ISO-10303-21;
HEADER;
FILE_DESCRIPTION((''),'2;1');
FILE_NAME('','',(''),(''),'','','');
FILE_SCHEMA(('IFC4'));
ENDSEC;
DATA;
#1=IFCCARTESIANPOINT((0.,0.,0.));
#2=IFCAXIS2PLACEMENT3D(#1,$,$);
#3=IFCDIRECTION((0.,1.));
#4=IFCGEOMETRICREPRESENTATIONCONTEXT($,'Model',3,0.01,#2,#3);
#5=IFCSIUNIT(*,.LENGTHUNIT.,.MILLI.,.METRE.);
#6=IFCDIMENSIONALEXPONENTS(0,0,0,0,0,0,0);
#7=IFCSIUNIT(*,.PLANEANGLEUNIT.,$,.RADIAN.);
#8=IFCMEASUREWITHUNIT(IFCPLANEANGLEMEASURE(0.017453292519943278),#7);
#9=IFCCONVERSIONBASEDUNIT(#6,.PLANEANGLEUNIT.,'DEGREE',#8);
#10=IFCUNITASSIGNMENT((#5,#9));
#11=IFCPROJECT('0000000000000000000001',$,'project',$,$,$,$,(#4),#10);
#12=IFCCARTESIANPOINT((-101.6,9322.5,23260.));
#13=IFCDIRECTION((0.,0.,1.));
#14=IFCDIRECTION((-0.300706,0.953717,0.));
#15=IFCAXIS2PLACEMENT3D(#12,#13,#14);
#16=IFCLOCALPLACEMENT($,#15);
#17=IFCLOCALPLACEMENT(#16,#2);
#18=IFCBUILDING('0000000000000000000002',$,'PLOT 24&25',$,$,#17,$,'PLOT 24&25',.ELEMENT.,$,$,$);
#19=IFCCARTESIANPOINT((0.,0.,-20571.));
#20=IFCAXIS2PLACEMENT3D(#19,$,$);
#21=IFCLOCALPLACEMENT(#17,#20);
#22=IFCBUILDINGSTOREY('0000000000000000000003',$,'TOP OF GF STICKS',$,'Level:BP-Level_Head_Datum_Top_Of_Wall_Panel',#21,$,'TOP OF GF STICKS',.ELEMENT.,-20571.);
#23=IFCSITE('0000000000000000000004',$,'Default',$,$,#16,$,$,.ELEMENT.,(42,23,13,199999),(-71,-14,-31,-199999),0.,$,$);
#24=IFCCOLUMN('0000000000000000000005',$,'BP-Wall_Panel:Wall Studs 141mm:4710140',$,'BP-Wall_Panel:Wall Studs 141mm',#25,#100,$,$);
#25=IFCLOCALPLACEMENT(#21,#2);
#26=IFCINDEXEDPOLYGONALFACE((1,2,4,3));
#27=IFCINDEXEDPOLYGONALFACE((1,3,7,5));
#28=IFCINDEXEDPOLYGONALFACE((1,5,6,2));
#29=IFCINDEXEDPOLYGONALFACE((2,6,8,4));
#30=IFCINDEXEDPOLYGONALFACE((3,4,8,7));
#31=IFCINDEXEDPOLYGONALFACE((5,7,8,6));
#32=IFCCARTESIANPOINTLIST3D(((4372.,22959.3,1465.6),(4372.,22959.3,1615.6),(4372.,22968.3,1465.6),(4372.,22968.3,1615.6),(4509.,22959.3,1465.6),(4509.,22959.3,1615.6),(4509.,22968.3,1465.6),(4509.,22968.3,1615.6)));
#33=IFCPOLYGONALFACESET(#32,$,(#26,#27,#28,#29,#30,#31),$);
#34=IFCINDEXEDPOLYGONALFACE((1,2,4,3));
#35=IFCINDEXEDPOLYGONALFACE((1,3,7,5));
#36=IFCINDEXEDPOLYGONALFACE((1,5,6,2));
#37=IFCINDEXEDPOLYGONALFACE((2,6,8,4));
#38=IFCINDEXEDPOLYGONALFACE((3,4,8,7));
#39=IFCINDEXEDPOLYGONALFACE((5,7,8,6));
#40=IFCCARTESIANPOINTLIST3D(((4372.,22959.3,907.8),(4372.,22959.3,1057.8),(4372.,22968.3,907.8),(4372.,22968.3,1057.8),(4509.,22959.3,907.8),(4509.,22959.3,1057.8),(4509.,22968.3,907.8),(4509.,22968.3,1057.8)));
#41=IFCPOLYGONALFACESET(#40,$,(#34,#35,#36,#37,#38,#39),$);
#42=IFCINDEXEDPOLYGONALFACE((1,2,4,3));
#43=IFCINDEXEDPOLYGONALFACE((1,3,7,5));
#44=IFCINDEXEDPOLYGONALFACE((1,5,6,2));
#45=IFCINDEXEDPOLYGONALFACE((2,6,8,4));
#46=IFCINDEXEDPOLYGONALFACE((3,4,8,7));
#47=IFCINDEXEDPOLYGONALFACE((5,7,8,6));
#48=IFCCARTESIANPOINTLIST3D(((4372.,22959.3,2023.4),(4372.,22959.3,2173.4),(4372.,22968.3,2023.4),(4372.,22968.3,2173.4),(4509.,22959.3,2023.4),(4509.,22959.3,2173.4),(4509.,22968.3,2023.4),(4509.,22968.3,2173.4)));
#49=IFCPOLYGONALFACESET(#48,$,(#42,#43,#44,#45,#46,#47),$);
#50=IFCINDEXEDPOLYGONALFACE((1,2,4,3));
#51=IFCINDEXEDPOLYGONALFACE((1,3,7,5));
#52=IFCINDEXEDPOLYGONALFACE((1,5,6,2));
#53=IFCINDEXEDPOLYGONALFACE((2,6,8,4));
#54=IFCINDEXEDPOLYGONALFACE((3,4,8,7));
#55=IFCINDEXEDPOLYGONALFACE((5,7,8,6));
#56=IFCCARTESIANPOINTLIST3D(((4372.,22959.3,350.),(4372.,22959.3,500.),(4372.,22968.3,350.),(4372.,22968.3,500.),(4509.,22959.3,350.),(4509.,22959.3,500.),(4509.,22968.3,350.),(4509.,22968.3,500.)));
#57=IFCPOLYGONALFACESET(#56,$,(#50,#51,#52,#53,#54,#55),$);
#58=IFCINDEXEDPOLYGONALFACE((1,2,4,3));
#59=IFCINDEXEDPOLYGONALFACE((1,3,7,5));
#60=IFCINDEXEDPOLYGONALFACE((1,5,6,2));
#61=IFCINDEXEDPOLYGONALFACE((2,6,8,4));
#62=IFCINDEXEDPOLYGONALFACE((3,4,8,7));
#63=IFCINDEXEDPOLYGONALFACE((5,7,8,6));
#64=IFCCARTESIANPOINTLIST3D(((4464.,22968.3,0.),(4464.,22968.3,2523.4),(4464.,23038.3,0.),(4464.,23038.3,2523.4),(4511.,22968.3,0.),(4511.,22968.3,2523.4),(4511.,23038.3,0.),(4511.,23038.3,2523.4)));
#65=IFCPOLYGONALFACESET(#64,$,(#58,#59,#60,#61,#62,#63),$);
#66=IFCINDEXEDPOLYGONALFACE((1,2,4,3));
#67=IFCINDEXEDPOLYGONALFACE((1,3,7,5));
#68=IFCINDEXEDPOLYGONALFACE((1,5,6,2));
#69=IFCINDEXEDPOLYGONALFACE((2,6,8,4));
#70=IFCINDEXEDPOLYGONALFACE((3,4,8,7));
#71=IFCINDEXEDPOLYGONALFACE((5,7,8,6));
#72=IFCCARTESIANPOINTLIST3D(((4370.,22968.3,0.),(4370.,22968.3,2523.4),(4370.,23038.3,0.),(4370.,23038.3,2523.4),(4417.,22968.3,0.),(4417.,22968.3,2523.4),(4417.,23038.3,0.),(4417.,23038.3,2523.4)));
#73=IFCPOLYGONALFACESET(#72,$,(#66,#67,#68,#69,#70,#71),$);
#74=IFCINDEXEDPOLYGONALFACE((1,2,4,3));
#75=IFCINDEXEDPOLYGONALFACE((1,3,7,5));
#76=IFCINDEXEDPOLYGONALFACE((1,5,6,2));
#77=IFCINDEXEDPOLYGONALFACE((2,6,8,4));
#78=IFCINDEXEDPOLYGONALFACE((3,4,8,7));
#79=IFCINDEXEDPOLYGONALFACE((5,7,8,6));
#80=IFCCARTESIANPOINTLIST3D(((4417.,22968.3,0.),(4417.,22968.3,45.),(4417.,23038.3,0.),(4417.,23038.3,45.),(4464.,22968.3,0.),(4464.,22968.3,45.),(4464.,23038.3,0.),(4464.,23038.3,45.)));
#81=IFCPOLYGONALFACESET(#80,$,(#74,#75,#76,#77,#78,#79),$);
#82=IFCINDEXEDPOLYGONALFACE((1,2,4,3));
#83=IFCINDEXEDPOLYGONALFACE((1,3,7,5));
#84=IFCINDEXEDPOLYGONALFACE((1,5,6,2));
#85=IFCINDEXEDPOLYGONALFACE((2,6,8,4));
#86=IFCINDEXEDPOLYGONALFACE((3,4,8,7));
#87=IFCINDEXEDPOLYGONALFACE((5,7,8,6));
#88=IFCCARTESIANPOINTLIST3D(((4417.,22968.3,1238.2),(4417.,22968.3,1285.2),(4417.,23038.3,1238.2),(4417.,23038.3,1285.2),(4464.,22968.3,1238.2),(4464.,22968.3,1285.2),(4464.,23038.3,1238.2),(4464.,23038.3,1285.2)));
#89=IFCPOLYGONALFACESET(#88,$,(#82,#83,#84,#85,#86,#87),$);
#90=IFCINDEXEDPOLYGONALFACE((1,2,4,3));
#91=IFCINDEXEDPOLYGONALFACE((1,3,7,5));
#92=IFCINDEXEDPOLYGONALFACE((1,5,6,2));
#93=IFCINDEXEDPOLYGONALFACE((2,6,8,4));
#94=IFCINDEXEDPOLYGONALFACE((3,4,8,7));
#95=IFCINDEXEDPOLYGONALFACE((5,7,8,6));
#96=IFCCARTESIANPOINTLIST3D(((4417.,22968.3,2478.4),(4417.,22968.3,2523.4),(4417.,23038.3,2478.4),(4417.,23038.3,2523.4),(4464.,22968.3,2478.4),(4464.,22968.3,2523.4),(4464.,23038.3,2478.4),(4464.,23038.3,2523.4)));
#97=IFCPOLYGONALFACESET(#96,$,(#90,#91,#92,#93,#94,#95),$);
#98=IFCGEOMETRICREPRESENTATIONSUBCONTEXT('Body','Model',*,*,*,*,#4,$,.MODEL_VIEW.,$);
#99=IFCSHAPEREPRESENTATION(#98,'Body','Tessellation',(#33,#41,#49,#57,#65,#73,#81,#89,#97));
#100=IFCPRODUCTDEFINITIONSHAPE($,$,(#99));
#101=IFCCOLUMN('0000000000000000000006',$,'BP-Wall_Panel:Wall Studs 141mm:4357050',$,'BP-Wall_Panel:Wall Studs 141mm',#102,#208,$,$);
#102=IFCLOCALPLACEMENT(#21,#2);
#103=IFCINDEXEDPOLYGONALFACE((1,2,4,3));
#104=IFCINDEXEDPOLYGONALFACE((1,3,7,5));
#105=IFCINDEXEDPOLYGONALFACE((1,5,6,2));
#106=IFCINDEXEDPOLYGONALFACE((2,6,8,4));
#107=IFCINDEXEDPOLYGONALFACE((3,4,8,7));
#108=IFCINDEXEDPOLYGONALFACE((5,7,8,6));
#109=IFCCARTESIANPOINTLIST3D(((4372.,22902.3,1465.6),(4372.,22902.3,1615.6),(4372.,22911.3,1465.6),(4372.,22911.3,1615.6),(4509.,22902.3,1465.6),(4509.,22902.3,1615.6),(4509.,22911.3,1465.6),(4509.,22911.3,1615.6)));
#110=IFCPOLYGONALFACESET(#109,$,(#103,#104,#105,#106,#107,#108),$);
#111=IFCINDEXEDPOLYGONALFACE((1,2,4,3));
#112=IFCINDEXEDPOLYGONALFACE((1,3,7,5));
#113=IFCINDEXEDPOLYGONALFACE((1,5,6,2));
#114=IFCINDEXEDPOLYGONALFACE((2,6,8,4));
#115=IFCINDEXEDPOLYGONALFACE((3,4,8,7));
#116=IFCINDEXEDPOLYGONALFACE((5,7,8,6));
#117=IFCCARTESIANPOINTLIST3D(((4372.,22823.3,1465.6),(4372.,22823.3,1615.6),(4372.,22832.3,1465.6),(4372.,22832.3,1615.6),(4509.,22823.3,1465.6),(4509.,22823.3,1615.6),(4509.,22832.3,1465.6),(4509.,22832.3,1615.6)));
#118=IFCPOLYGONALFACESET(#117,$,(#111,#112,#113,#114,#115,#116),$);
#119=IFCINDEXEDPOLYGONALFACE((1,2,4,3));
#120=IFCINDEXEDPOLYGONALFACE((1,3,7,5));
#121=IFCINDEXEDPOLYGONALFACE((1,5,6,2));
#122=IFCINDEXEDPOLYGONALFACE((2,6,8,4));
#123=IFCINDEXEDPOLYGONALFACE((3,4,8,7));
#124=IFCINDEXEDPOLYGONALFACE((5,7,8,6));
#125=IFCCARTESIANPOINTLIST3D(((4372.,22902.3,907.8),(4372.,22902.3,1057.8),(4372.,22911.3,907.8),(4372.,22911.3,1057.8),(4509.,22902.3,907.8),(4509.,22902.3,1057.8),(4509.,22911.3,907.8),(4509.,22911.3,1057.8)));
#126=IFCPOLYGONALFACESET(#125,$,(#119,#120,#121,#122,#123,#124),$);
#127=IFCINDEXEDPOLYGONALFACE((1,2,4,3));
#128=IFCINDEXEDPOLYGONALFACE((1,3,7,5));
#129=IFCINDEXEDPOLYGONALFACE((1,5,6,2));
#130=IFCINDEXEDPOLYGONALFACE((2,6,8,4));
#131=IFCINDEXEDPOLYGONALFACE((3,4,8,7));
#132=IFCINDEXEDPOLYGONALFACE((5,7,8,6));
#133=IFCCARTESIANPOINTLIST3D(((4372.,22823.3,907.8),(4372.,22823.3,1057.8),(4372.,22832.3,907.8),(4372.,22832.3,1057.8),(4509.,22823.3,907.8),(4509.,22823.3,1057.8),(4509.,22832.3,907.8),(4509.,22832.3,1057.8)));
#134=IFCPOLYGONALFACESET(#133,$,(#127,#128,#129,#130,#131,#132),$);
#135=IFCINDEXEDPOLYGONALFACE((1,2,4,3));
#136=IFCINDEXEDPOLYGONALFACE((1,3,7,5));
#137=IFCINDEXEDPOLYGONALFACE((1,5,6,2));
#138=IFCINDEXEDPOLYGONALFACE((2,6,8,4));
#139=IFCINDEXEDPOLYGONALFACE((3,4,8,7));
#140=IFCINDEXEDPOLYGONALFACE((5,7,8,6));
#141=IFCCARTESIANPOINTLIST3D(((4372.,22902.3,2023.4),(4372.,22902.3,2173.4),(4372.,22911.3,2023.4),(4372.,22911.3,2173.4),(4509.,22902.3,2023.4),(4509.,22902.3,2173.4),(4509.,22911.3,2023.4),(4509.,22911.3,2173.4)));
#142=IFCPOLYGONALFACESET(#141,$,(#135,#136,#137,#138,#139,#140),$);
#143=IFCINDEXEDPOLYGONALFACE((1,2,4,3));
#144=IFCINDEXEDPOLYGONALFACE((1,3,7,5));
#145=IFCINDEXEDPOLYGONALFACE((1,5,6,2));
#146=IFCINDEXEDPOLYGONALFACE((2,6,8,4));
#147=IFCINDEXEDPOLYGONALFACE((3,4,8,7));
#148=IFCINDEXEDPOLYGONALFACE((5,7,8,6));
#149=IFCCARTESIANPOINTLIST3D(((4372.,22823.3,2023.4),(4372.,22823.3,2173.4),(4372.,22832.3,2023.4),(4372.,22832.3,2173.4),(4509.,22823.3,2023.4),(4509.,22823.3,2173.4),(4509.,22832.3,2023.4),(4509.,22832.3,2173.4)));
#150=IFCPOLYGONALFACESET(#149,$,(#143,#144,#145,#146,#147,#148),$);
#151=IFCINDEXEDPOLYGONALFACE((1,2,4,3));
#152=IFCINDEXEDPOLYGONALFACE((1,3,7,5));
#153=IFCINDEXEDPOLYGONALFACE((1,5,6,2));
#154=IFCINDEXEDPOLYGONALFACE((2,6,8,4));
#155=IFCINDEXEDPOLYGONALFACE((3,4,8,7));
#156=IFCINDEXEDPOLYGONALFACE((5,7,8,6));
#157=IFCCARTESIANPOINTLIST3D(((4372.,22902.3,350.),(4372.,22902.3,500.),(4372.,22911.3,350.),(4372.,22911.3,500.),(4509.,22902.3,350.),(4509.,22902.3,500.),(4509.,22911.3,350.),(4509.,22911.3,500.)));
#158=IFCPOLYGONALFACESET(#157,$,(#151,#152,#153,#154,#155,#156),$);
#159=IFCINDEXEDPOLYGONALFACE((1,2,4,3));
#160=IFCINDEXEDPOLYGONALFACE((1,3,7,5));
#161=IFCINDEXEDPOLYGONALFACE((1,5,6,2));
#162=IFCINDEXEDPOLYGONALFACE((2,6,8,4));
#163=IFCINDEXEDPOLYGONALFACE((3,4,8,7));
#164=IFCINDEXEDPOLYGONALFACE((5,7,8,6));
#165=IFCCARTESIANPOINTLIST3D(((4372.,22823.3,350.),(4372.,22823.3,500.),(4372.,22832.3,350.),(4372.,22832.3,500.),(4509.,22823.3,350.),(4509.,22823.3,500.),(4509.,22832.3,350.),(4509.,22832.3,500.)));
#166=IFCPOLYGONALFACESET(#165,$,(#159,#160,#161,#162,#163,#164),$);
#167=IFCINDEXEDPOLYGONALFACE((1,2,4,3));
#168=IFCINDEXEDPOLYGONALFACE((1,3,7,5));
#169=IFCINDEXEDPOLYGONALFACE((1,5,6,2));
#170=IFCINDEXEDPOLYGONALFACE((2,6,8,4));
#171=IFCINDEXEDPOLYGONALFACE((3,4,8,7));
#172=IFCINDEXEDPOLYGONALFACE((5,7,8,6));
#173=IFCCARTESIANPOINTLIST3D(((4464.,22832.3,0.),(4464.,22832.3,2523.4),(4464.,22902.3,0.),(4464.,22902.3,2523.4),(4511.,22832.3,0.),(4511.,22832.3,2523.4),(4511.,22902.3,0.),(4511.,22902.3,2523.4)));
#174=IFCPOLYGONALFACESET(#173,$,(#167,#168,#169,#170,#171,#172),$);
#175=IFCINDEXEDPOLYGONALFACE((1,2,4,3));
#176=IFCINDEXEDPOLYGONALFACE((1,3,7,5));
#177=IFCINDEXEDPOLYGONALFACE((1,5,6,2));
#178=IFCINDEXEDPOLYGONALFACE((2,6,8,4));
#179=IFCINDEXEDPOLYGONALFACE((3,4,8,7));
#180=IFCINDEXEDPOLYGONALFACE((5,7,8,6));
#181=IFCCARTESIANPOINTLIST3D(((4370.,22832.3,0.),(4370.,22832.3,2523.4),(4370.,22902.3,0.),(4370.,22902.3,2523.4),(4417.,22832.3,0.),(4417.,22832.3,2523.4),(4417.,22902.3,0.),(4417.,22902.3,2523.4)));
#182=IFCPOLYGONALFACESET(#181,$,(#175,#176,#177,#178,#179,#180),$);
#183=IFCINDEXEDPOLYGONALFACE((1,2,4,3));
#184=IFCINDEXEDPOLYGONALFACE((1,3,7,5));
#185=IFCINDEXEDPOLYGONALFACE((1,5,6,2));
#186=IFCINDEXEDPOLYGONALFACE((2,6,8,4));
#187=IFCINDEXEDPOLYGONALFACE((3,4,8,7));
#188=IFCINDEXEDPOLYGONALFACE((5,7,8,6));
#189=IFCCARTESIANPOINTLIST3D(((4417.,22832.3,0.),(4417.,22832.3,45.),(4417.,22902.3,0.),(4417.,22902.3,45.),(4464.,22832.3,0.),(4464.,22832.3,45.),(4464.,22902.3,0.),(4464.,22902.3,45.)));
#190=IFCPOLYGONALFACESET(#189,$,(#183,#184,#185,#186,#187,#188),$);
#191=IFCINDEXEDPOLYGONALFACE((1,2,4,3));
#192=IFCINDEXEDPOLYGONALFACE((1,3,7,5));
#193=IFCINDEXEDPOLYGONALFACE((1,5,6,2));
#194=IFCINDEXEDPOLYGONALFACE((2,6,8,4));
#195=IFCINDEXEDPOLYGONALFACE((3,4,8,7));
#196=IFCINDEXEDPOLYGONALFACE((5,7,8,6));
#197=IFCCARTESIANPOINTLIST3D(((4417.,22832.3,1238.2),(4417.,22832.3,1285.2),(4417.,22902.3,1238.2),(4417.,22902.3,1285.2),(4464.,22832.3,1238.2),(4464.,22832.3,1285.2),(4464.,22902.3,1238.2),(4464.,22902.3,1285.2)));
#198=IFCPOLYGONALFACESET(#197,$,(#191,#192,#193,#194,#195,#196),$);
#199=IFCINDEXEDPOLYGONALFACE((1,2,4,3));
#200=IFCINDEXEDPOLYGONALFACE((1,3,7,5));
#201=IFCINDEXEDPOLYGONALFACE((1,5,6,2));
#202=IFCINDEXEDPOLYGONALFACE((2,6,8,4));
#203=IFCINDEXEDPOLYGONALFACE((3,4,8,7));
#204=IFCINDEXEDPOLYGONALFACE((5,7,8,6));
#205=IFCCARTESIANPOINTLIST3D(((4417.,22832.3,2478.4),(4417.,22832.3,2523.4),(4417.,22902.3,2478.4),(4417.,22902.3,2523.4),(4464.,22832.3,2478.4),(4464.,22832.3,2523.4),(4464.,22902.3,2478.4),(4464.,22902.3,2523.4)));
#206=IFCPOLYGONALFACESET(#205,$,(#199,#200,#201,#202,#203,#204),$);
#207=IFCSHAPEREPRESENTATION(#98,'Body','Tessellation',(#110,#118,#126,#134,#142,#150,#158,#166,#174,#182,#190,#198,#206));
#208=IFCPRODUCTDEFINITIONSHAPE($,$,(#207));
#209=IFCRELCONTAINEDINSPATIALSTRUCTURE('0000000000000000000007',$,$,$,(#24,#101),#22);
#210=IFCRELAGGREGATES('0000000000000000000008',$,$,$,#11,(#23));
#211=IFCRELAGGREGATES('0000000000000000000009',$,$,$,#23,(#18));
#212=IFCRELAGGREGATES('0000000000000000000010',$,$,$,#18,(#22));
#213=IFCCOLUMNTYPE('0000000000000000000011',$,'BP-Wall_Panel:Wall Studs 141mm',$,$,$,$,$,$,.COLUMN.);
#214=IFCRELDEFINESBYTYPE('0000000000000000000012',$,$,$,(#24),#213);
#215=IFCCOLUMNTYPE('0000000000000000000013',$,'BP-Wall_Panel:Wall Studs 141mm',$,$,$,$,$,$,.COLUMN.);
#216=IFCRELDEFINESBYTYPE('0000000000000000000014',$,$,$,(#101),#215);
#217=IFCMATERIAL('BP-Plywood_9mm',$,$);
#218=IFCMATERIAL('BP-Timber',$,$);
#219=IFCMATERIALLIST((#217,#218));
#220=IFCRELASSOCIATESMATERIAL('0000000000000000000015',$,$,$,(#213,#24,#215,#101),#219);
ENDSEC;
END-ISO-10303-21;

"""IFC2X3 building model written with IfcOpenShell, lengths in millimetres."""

from ifc_helpers import new_model, entity, si_unit, converted_unit, direction, frame, frame_2d, origin, origin_2d_with_axis, place, context, subcontext, project, spatial, rectangle, extrude, source, transform, mapped, material, material_list, type_object, type_shapes, element, save


model = new_model("IFC2X3")

# Units and contexts
model_context = context("Model", 3, precision=0.01, world=origin(), true_north=direction((0.0, 1.0)))
body_context = subcontext(model_context, "Body", "Model", "MODEL_VIEW")
ifc_project = project(units=[si_unit("LENGTHUNIT", "METRE", prefix="MILLI"), converted_unit("PLANEANGLEUNIT", "DEGREE", entity("IfcPlaneAngleMeasure", 0.017453292519943278), si_unit("PLANEANGLEUNIT", "RADIAN"), dimensions=[0, 0, 0, 0, 0, 0, 0])], contexts=[model_context])

# Site, building, storey
site_placement = place(None, frame((-101.6, 9322.5, 23260.0), z_axis=(0.0, 0.0, 1.0), x_axis=(-0.300706, 0.953717, 0.0)))
site = spatial("IfcSite", under=ifc_project, at=site_placement, Name="Default", CompositionType="ELEMENT", RefLatitude=(42, 23, 13, 199999), RefLongitude=(-71, -14, -31, -199999), RefElevation=0.0)
building_placement = place(site_placement, origin())
building = spatial("IfcBuilding", under=site, at=building_placement, Name="PLOT 24&25", LongName="PLOT 24&25", CompositionType="ELEMENT")
storey_placement = place(building_placement, frame((0.0, 0.0, -20571.0)))
storey = spatial("IfcBuildingStorey", under=building, at=storey_placement, Name="TOP OF GF STICKS", ObjectType="Level:BP-Level_Head_Datum_Top_Of_Wall_Panel", LongName="TOP OF GF STICKS", CompositionType="ELEMENT", Elevation=-20571.0)

# Columns
ifc_material_1 = material(Name="BP-Plywood_9mm")
ifc_material_2 = material(Name="BP-Timber")
ifc_material_list = material_list([ifc_material_1, ifc_material_2])
column_type_1 = type_object("IfcColumnType", Name="BP-Wall_Panel:Wall Studs 141mm", PredefinedType="COLUMN", material=ifc_material_list)
shared_shape_1 = source(origin(), body_context, "Body", "SweptSolid", [
    extrude(rectangle(XDim=9.0, YDim=137.0, at=origin_2d_with_axis()), frame((-39.5, 0.0, -19105.4), z_axis=(0.0, 0.0, 1.0), x_axis=(-1.0, 0.0, 0.0)), (0.0, 0.0, 1.0), 150.0),
    extrude(rectangle(XDim=9.0, YDim=137.0, at=origin_2d_with_axis()), frame((-39.5, 0.0, -19663.2), z_axis=(0.0, 0.0, 1.0), x_axis=(-1.0, 0.0, 0.0)), (0.0, 0.0, 1.0), 150.0),
    extrude(rectangle(XDim=9.0, YDim=137.0, at=origin_2d_with_axis()), frame((-39.5, 0.0, -18547.6), z_axis=(0.0, 0.0, 1.0), x_axis=(-1.0, 0.0, 0.0)), (0.0, 0.0, 1.0), 150.0),
    extrude(rectangle(XDim=9.0, YDim=137.0, at=origin_2d_with_axis()), frame((-39.5, 0.0, -20221.0), z_axis=(0.0, 0.0, 1.0), x_axis=(-1.0, 0.0, 0.0)), (0.0, 0.0, 1.0), 150.0),
    extrude(rectangle(XDim=70.0, YDim=47.0, at=origin_2d_with_axis()), frame((0.0, -47.0, -20571.0), z_axis=(0.0, 0.0, 1.0), x_axis=(-1.0, 0.0, 0.0)), (0.0, 0.0, 1.0), 2523.4),
    extrude(rectangle(XDim=70.0, YDim=47.0, at=origin_2d_with_axis()), frame((0.0, 47.0, -20571.0), z_axis=(0.0, 0.0, 1.0), x_axis=(-1.0, 0.0, 0.0)), (0.0, 0.0, 1.0), 2523.4),
    extrude(rectangle(XDim=47.0, YDim=70.0, at=origin_2d_with_axis()), frame((0.0, 0.0, -20571.0), z_axis=(0.0, 0.0, 1.0), x_axis=(0.0, -1.0, 0.0)), (0.0, 0.0, 1.0), 45.0),
    extrude(rectangle(XDim=47.0, YDim=70.0, at=origin_2d_with_axis()), frame((0.0, 0.0, -19332.8), z_axis=(0.0, 0.0, 1.0), x_axis=(0.0, -1.0, 0.0)), (0.0, 0.0, 1.0), 47.0),
    extrude(rectangle(XDim=47.0, YDim=70.0, at=origin_2d_with_axis()), frame((0.0, 0.0, -18092.6), z_axis=(0.0, 0.0, 1.0), x_axis=(0.0, -1.0, 0.0)), (0.0, 0.0, 1.0), 45.0),
])
type_shapes(column_type_1, [shared_shape_1])
for number, where, z_axis, x_axis, name in (
    (1, (4440.5, 23003.3, 20571.0), (0.0, 0.0, 1.0), (0.0, 1.0, 0.0), "BP-Wall_Panel:Wall Studs 141mm:4710140"),
):
    element("IfcColumn", number, at=place(storey_placement, frame(where, z_axis=z_axis, x_axis=x_axis)), inside=storey, type_object=column_type_1, material=ifc_material_list, Name=name, ObjectType="BP-Wall_Panel:Wall Studs 141mm", context=body_context, shape_type="MappedRepresentation", body=[
        mapped(shared_shape_1, transform((0.0, 0.0, 0.0), scale=1.0)),
    ])
column_type_2 = type_object("IfcColumnType", Name="BP-Wall_Panel:Wall Studs 141mm", PredefinedType="COLUMN", material=ifc_material_list)
shared_shape_2 = source(origin(), body_context, "Body", "SweptSolid", [
    extrude(rectangle(XDim=137.0, YDim=9.0, at=origin_2d_with_axis()), frame((39.5, 0.0, -19105.4), z_axis=(0.0, 0.0, 1.0), x_axis=(0.0, -1.0, 0.0)), (0.0, 0.0, 1.0), 150.0),
    extrude(rectangle(XDim=9.0, YDim=137.0, at=origin_2d_with_axis()), frame((-39.5, 0.0, -19105.4), z_axis=(0.0, 0.0, 1.0), x_axis=(-1.0, 0.0, 0.0)), (0.0, 0.0, 1.0), 150.0),
    extrude(rectangle(XDim=137.0, YDim=9.0, at=origin_2d_with_axis()), frame((39.5, 0.0, -19663.2), z_axis=(0.0, 0.0, 1.0), x_axis=(0.0, -1.0, 0.0)), (0.0, 0.0, 1.0), 150.0),
    extrude(rectangle(XDim=9.0, YDim=137.0, at=origin_2d_with_axis()), frame((-39.5, 0.0, -19663.2), z_axis=(0.0, 0.0, 1.0), x_axis=(-1.0, 0.0, 0.0)), (0.0, 0.0, 1.0), 150.0),
    extrude(rectangle(XDim=137.0, YDim=9.0, at=frame_2d((0.0, 0.0), x_axis=(1.0, 0.0))), frame((39.5, 0.0, -18547.6), z_axis=(0.0, 0.0, 1.0), x_axis=(0.0, -1.0, 0.0)), (0.0, 0.0, 1.0), 150.0),
    extrude(rectangle(XDim=9.0, YDim=137.0, at=origin_2d_with_axis()), frame((-39.5, 0.0, -18547.6), z_axis=(0.0, 0.0, 1.0), x_axis=(-1.0, 0.0, 0.0)), (0.0, 0.0, 1.0), 150.0),
    extrude(rectangle(XDim=137.0, YDim=9.0, at=origin_2d_with_axis()), frame((39.5, 0.0, -20221.0), z_axis=(0.0, 0.0, 1.0), x_axis=(0.0, -1.0, 0.0)), (0.0, 0.0, 1.0), 150.0),
    extrude(rectangle(XDim=9.0, YDim=137.0, at=origin_2d_with_axis()), frame((-39.5, 0.0, -20221.0), z_axis=(0.0, 0.0, 1.0), x_axis=(-1.0, 0.0, 0.0)), (0.0, 0.0, 1.0), 150.0),
    extrude(rectangle(XDim=70.0, YDim=47.0, at=origin_2d_with_axis()), frame((0.0, -47.0, -20571.0), z_axis=(0.0, 0.0, 1.0), x_axis=(-1.0, 0.0, 0.0)), (0.0, 0.0, 1.0), 2523.4),
    extrude(rectangle(XDim=70.0, YDim=47.0, at=origin_2d_with_axis()), frame((0.0, 47.0, -20571.0), z_axis=(0.0, 0.0, 1.0), x_axis=(-1.0, 0.0, 0.0)), (0.0, 0.0, 1.0), 2523.4),
    extrude(rectangle(XDim=47.0, YDim=70.0, at=origin_2d_with_axis()), frame((0.0, 0.0, -20571.0), z_axis=(0.0, 0.0, 1.0), x_axis=(0.0, -1.0, 0.0)), (0.0, 0.0, 1.0), 45.0),
    extrude(rectangle(XDim=47.0, YDim=70.0, at=origin_2d_with_axis()), frame((0.0, 0.0, -19332.8), z_axis=(0.0, 0.0, 1.0), x_axis=(0.0, -1.0, 0.0)), (0.0, 0.0, 1.0), 47.0),
    extrude(rectangle(XDim=47.0, YDim=70.0, at=origin_2d_with_axis()), frame((0.0, 0.0, -18092.6), z_axis=(0.0, 0.0, 1.0), x_axis=(0.0, -1.0, 0.0)), (0.0, 0.0, 1.0), 45.0),
])
type_shapes(column_type_2, [shared_shape_2])
for number, where, z_axis, x_axis, name in (
    (2, (4440.5, 22867.3, 20571.0), (0.0, 0.0, 1.0), (0.0, 1.0, 0.0), "BP-Wall_Panel:Wall Studs 141mm:4357050"),
):
    element("IfcColumn", number, at=place(storey_placement, frame(where, z_axis=z_axis, x_axis=x_axis)), inside=storey, type_object=column_type_2, material=ifc_material_list, Name=name, ObjectType="BP-Wall_Panel:Wall Studs 141mm", context=body_context, shape_type="MappedRepresentation", body=[
        mapped(shared_shape_2, transform((0.0, 0.0, 0.0), scale=1.0)),
    ])

save(model, "model.ifc")
